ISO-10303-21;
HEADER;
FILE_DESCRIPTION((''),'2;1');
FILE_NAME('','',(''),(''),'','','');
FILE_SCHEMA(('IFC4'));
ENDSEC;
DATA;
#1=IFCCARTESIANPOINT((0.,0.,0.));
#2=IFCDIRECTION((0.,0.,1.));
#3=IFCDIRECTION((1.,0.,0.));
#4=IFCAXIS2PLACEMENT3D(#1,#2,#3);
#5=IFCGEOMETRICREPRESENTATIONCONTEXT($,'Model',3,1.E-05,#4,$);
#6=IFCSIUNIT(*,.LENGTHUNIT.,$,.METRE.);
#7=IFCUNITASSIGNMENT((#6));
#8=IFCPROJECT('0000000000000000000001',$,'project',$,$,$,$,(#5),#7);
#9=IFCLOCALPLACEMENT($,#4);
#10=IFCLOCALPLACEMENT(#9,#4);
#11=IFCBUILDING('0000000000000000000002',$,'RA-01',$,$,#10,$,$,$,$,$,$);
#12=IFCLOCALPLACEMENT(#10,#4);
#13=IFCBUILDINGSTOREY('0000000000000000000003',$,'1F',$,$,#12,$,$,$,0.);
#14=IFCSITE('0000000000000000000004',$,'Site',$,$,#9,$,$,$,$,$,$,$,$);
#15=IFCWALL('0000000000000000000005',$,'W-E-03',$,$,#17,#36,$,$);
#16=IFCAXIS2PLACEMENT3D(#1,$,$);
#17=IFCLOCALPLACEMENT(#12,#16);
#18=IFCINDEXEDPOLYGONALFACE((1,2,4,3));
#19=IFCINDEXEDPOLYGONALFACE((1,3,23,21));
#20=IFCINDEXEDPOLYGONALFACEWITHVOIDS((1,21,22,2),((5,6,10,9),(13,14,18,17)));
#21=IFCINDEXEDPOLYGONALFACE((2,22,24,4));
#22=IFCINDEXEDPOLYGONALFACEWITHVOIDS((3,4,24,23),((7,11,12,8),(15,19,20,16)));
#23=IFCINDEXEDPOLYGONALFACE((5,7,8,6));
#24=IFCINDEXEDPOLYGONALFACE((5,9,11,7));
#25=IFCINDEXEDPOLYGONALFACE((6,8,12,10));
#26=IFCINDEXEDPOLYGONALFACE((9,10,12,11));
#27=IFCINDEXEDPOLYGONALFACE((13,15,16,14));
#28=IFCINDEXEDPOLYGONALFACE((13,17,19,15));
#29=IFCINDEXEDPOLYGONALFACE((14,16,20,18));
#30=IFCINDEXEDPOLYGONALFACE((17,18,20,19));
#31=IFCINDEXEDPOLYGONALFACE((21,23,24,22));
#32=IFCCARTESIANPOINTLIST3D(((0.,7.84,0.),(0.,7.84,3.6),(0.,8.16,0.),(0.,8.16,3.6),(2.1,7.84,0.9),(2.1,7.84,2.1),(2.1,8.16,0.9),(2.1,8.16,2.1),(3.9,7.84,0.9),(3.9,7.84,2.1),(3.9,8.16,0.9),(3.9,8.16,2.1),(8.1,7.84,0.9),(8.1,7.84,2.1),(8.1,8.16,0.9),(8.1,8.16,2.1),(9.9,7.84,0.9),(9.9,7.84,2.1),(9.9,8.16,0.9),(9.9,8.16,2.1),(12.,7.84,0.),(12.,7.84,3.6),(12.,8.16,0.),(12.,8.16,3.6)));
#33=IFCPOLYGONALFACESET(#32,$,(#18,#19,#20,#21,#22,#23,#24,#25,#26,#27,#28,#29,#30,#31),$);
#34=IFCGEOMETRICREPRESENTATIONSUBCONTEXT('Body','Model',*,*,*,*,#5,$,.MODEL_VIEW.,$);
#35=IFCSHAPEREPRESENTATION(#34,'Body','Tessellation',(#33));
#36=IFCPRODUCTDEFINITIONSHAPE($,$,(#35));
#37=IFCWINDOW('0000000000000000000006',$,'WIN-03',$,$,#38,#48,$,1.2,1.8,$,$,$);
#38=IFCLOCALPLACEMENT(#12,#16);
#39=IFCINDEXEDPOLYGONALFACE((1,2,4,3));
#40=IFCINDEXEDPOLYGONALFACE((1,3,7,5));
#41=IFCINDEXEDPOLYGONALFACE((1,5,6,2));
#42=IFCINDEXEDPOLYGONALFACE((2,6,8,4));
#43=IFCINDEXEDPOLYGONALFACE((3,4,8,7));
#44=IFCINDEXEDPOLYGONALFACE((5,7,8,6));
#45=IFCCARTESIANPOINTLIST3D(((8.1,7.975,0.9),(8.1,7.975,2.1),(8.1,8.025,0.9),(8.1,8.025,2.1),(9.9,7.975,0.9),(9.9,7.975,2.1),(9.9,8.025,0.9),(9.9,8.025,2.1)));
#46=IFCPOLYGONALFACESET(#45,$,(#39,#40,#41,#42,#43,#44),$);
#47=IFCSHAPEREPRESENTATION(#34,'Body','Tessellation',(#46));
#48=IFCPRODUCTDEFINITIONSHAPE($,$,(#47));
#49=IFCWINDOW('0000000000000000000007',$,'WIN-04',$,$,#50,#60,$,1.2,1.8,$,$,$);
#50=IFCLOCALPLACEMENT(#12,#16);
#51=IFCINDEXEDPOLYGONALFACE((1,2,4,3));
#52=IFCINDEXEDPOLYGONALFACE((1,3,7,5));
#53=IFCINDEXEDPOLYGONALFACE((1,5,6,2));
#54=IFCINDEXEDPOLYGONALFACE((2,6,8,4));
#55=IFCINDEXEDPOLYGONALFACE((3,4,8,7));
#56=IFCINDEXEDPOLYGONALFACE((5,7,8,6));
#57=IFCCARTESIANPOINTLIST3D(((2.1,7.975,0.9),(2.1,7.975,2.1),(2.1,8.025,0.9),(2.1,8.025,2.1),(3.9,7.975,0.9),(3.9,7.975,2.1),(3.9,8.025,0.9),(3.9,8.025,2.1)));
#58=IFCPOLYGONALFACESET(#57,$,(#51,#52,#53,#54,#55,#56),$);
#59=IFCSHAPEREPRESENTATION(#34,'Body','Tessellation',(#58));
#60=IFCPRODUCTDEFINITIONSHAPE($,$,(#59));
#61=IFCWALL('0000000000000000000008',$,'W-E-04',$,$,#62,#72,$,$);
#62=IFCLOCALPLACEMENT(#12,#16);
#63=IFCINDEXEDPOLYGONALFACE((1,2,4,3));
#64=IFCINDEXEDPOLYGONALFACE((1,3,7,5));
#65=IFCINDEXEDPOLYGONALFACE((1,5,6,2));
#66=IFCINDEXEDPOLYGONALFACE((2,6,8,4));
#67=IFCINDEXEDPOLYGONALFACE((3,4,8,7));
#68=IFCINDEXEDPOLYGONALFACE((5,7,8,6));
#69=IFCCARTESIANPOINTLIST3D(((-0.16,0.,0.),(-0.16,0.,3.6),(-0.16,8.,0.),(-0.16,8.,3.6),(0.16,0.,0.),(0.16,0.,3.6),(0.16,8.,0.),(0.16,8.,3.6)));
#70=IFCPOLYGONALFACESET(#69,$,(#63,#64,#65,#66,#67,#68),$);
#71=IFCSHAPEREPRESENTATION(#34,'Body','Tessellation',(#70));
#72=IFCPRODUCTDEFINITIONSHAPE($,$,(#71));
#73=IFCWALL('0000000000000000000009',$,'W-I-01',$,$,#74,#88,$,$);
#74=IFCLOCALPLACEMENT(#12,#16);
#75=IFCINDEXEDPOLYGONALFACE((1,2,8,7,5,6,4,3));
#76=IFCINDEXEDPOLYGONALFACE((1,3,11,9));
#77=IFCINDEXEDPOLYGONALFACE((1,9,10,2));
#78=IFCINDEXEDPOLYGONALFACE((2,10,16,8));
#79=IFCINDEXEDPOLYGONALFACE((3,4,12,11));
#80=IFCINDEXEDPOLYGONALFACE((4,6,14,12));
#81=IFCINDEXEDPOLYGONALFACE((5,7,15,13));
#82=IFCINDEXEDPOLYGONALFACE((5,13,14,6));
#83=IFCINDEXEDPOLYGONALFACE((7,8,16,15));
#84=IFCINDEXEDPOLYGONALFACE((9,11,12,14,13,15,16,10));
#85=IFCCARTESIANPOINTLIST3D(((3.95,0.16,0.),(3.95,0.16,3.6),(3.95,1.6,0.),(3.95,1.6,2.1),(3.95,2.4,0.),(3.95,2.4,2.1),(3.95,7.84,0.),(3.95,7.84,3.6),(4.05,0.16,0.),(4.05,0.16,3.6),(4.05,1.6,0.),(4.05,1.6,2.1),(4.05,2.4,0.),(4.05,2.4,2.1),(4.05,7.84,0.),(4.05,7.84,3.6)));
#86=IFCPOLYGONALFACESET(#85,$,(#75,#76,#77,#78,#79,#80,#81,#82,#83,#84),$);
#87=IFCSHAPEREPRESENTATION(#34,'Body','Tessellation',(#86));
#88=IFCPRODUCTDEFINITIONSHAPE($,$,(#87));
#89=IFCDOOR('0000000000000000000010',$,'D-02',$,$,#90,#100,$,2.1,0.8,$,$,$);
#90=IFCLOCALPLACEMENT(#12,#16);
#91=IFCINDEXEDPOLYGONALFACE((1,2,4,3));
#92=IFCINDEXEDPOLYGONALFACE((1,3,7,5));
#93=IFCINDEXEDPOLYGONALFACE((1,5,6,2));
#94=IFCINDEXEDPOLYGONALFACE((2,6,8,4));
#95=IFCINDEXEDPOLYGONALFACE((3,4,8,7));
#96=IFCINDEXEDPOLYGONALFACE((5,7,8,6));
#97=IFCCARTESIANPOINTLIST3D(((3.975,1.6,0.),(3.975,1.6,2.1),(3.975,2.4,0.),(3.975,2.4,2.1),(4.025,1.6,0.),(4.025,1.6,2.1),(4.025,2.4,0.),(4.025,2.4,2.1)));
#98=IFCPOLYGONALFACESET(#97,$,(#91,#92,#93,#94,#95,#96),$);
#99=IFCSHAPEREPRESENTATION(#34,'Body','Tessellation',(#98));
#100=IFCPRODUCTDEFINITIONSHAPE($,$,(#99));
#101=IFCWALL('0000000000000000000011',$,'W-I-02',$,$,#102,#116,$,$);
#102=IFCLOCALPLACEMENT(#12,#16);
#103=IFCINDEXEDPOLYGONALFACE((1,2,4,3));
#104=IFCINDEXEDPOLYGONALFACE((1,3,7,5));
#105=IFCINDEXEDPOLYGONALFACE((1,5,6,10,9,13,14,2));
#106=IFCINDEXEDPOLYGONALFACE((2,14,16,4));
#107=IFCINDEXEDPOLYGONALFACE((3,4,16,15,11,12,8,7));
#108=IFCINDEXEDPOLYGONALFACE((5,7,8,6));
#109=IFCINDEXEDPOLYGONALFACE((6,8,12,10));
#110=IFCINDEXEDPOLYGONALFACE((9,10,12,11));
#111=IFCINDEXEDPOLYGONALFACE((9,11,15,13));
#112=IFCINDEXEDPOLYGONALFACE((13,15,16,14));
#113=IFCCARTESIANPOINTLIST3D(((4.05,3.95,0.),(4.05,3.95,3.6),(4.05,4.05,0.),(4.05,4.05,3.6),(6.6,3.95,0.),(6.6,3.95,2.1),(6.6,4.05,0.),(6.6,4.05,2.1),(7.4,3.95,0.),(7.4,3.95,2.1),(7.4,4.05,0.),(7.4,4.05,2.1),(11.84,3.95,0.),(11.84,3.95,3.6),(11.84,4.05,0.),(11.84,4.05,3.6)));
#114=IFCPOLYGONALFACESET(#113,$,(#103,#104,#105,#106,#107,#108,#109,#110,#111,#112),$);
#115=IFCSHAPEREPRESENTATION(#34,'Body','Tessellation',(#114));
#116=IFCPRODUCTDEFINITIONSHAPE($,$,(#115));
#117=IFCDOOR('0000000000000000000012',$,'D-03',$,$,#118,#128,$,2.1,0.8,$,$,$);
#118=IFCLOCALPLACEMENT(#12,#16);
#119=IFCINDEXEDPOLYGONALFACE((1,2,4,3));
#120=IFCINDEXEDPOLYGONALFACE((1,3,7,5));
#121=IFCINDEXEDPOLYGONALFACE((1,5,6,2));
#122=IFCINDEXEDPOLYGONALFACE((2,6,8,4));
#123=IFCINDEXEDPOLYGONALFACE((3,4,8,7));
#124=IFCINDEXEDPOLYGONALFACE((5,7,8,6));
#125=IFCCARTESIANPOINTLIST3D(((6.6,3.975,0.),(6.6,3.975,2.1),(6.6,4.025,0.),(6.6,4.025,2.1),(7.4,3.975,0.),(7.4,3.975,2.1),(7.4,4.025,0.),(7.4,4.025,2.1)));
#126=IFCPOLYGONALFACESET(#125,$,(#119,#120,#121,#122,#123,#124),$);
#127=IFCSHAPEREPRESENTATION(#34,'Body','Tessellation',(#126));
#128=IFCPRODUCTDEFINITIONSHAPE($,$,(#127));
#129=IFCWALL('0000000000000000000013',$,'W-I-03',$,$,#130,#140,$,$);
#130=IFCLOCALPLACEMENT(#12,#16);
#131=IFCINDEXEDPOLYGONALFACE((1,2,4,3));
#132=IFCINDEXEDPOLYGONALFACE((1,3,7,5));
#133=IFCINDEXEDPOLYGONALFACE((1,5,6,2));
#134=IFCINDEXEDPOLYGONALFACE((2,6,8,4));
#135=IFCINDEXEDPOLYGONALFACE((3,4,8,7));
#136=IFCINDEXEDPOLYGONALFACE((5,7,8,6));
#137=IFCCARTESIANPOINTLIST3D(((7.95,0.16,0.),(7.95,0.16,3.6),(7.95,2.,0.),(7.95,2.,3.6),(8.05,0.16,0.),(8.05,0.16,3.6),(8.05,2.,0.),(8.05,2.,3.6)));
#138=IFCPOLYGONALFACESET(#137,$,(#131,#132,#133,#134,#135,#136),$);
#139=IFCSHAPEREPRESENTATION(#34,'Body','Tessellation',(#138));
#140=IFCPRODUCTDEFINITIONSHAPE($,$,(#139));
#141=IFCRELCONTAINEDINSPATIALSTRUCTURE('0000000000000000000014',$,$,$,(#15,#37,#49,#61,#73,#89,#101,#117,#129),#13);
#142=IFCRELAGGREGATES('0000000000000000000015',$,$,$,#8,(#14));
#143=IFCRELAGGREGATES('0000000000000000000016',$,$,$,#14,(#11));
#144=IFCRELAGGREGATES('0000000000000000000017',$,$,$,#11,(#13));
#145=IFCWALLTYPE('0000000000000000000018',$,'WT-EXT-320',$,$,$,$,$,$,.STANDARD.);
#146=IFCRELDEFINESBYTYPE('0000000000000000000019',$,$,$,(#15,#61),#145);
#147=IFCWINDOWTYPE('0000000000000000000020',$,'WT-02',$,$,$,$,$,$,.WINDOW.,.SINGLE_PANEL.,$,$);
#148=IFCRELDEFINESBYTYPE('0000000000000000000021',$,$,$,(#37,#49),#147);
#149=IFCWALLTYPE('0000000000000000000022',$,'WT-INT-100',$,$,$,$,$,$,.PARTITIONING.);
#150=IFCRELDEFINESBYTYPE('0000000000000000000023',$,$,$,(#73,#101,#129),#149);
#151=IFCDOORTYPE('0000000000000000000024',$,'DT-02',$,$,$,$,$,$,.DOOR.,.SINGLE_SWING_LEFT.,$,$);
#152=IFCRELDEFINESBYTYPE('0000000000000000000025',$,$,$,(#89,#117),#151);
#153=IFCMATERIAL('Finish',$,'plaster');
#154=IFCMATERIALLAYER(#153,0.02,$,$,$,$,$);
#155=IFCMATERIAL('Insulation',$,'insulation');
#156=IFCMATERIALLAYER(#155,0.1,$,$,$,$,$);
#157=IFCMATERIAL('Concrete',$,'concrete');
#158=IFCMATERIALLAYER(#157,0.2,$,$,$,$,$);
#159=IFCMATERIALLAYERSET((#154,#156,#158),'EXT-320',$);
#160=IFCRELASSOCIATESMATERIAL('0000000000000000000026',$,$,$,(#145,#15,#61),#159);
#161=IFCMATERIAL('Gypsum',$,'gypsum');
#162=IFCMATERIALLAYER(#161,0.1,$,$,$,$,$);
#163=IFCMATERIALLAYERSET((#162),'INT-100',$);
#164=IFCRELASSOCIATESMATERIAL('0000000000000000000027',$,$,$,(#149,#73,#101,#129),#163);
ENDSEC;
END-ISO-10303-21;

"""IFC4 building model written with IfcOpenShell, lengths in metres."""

from ifc_helpers import new_model, si_unit, frame, frame_2d, origin_with_axes, origin_2d_with_axis, place, context, subcontext, project, spatial, rectangle, extrude, material, layer, layer_set, layer_usage, type_object, element, fill, save


model = new_model("IFC4")

# Units and contexts
model_context = context("Model", 3, precision=1e-05, world=origin_with_axes())
body_context = subcontext(model_context, "Body", "Model", "MODEL_VIEW")
ifc_project = project(units=[si_unit("LENGTHUNIT", "METRE")], contexts=[model_context])

# Site, building, storey
site_placement = place(None, origin_with_axes())
site = spatial("IfcSite", under=ifc_project, at=site_placement, Name="Site")
building_placement = place(site_placement, origin_with_axes())
building = spatial("IfcBuilding", under=site, at=building_placement, Name="RA-01")
storey_placement = place(building_placement, origin_with_axes())
storey = spatial("IfcBuildingStorey", under=building, at=storey_placement, Name="1F", Elevation=0.0)

# Shared definitions
ifc_material_1 = material(Name="Concrete", Category="concrete")

# Shared definitions
ifc_material_2 = material(Name="Finish", Category="plaster")
ifc_layer_1 = layer(ifc_material_2, 0.02)
ifc_material_3 = material(Name="Insulation", Category="insulation")
ifc_layer_2 = layer(ifc_material_3, 0.1)
ifc_layer_3 = layer(ifc_material_1, 0.2)
ifc_layer_set_1 = layer_set([ifc_layer_1, ifc_layer_2, ifc_layer_3], Name="EXT-320")
wall_type_1 = type_object("IfcWallType", Name="WT-EXT-320", PredefinedType="STANDARD", material=ifc_layer_set_1)

# Wall, openings, windows
ifc_layer_usage_1 = layer_usage(ifc_layer_set_1, "AXIS2", "POSITIVE", -0.16)
wall_1_placement = place(storey_placement, frame((12.0, 8.0, 0.0), z_axis=(0.0, 0.0, 1.0), x_axis=(-1.0, 0.0, 0.0)))
wall_1 = element("IfcWall", 1, at=wall_1_placement, inside=storey, type_object=wall_type_1, material=ifc_layer_usage_1, Name="W-E-03", context=body_context, shape_type="SweptSolid", body=[
    extrude(rectangle(XDim=12.0, YDim=0.32, at=frame_2d((6.0, 0.0), x_axis=(1.0, 0.0))), origin_with_axes(), (0.0, 0.0, 1.0), 3.6),
])
opening_1_placement = place(wall_1_placement, frame((3.0, 0.0, 0.9), z_axis=(0.0, 0.0, 1.0), x_axis=(1.0, 0.0, 0.0)))
opening_1 = element("IfcOpeningElement", 2, at=opening_1_placement, cuts=wall_1, PredefinedType="OPENING", context=body_context, shape_type="SweptSolid", body=[
    extrude(rectangle(XDim=1.8, YDim=0.42, at=origin_2d_with_axis()), origin_with_axes(), (0.0, 0.0, 1.0), 1.2),
])
opening_2_placement = place(wall_1_placement, frame((9.0, 0.0, 0.9), z_axis=(0.0, 0.0, 1.0), x_axis=(1.0, 0.0, 0.0)))
opening_2 = element("IfcOpeningElement", 3, at=opening_2_placement, cuts=wall_1, PredefinedType="OPENING", context=body_context, shape_type="SweptSolid", body=[
    extrude(rectangle(XDim=1.8, YDim=0.42, at=origin_2d_with_axis()), origin_with_axes(), (0.0, 0.0, 1.0), 1.2),
])
window_type_1 = type_object("IfcWindowType", Name="WT-02", PartitioningType="SINGLE_PANEL", PredefinedType="WINDOW")
window_1_placement = place(opening_1_placement, origin_with_axes())
window_1 = element("IfcWindow", 4, at=window_1_placement, inside=storey, type_object=window_type_1, Name="WIN-03", OverallHeight=1.2, OverallWidth=1.8, context=body_context, shape_type="SweptSolid", body=[
    extrude(rectangle(XDim=1.8, YDim=0.05, at=origin_2d_with_axis()), origin_with_axes(), (0.0, 0.0, 1.0), 1.2),
])
fill(opening_1, window_1)
window_2_placement = place(opening_2_placement, origin_with_axes())
window_2 = element("IfcWindow", 5, at=window_2_placement, inside=storey, type_object=window_type_1, Name="WIN-04", OverallHeight=1.2, OverallWidth=1.8, context=body_context, shape_type="SweptSolid", body=[
    extrude(rectangle(XDim=1.8, YDim=0.05, at=origin_2d_with_axis()), origin_with_axes(), (0.0, 0.0, 1.0), 1.2),
])
fill(opening_2, window_2)

# Wall
ifc_layer_usage_2 = layer_usage(ifc_layer_set_1, "AXIS2", "POSITIVE", -0.16)
wall_2_placement = place(storey_placement, frame((0.0, 8.0, 0.0), z_axis=(0.0, 0.0, 1.0), x_axis=(0.0, -1.0, 0.0)))
element("IfcWall", 6, at=wall_2_placement, inside=storey, type_object=wall_type_1, material=ifc_layer_usage_2, Name="W-E-04", context=body_context, shape_type="SweptSolid", body=[
    extrude(rectangle(XDim=8.0, YDim=0.32, at=frame_2d((4.0, 0.0), x_axis=(1.0, 0.0))), origin_with_axes(), (0.0, 0.0, 1.0), 3.6),
])

# Walls, openings, doors
ifc_material_4 = material(Name="Gypsum", Category="gypsum")
ifc_layer_4 = layer(ifc_material_4, 0.1)
ifc_layer_set_2 = layer_set([ifc_layer_4], Name="INT-100")
ifc_layer_usage_3 = layer_usage(ifc_layer_set_2, "AXIS2", "POSITIVE", -0.05)
wall_type_2 = type_object("IfcWallType", Name="WT-INT-100", PredefinedType="PARTITIONING", material=ifc_layer_set_2)
wall_3_placement = place(storey_placement, frame((4.0, 0.16, 0.0), z_axis=(0.0, 0.0, 1.0), x_axis=(0.0, 1.0, 0.0)))
wall_3 = element("IfcWall", 7, at=wall_3_placement, inside=storey, type_object=wall_type_2, material=ifc_layer_usage_3, Name="W-I-01", context=body_context, shape_type="SweptSolid", body=[
    extrude(rectangle(XDim=7.68, YDim=0.1, at=frame_2d((3.84, 0.0), x_axis=(1.0, 0.0))), origin_with_axes(), (0.0, 0.0, 1.0), 3.6),
])
opening_3_placement = place(wall_3_placement, frame((1.84, 0.0, 0.0), z_axis=(0.0, 0.0, 1.0), x_axis=(1.0, 0.0, 0.0)))
opening_3 = element("IfcOpeningElement", 8, at=opening_3_placement, cuts=wall_3, PredefinedType="OPENING", context=body_context, shape_type="SweptSolid", body=[
    extrude(rectangle(XDim=0.8, YDim=0.2, at=origin_2d_with_axis()), origin_with_axes(), (0.0, 0.0, 1.0), 2.1),
])
door_type_1 = type_object("IfcDoorType", Name="DT-02", OperationType="SINGLE_SWING_LEFT", PredefinedType="DOOR")
door_1_placement = place(opening_3_placement, origin_with_axes())
door_1 = element("IfcDoor", 9, at=door_1_placement, inside=storey, type_object=door_type_1, Name="D-02", OverallHeight=2.1, OverallWidth=0.8, context=body_context, shape_type="SweptSolid", body=[
    extrude(rectangle(XDim=0.8, YDim=0.05, at=origin_2d_with_axis()), origin_with_axes(), (0.0, 0.0, 1.0), 2.1),
])
fill(opening_3, door_1)
ifc_layer_usage_4 = layer_usage(ifc_layer_set_2, "AXIS2", "POSITIVE", -0.05)
wall_4_placement = place(storey_placement, frame((4.05, 4.0, 0.0), z_axis=(0.0, 0.0, 1.0), x_axis=(1.0, 0.0, 0.0)))
wall_4 = element("IfcWall", 10, at=wall_4_placement, inside=storey, type_object=wall_type_2, material=ifc_layer_usage_4, Name="W-I-02", context=body_context, shape_type="SweptSolid", body=[
    extrude(rectangle(XDim=7.79, YDim=0.1, at=frame_2d((3.895, 0.0), x_axis=(1.0, 0.0))), origin_with_axes(), (0.0, 0.0, 1.0), 3.6),
])
opening_4_placement = place(wall_4_placement, frame((2.95, 0.0, 0.0), z_axis=(0.0, 0.0, 1.0), x_axis=(1.0, 0.0, 0.0)))
opening_4 = element("IfcOpeningElement", 11, at=opening_4_placement, cuts=wall_4, PredefinedType="OPENING", context=body_context, shape_type="SweptSolid", body=[
    extrude(rectangle(XDim=0.8, YDim=0.2, at=origin_2d_with_axis()), origin_with_axes(), (0.0, 0.0, 1.0), 2.1),
])
door_2_placement = place(opening_4_placement, origin_with_axes())
door_2 = element("IfcDoor", 12, at=door_2_placement, inside=storey, type_object=door_type_1, Name="D-03", OverallHeight=2.1, OverallWidth=0.8, context=body_context, shape_type="SweptSolid", body=[
    extrude(rectangle(XDim=0.8, YDim=0.05, at=origin_2d_with_axis()), origin_with_axes(), (0.0, 0.0, 1.0), 2.1),
])
fill(opening_4, door_2)

# Wall
ifc_layer_usage_5 = layer_usage(ifc_layer_set_2, "AXIS2", "POSITIVE", -0.05)
wall_5_placement = place(storey_placement, frame((8.0, 0.16, 0.0), z_axis=(0.0, 0.0, 1.0), x_axis=(0.0, 1.0, 0.0)))
element("IfcWall", 13, at=wall_5_placement, inside=storey, type_object=wall_type_2, material=ifc_layer_usage_5, Name="W-I-03", context=body_context, shape_type="SweptSolid", body=[
    extrude(rectangle(XDim=1.84, YDim=0.1, at=frame_2d((0.92, 0.0), x_axis=(1.0, 0.0))), origin_with_axes(), (0.0, 0.0, 1.0), 3.6),
])

save(model, "model.ifc")
